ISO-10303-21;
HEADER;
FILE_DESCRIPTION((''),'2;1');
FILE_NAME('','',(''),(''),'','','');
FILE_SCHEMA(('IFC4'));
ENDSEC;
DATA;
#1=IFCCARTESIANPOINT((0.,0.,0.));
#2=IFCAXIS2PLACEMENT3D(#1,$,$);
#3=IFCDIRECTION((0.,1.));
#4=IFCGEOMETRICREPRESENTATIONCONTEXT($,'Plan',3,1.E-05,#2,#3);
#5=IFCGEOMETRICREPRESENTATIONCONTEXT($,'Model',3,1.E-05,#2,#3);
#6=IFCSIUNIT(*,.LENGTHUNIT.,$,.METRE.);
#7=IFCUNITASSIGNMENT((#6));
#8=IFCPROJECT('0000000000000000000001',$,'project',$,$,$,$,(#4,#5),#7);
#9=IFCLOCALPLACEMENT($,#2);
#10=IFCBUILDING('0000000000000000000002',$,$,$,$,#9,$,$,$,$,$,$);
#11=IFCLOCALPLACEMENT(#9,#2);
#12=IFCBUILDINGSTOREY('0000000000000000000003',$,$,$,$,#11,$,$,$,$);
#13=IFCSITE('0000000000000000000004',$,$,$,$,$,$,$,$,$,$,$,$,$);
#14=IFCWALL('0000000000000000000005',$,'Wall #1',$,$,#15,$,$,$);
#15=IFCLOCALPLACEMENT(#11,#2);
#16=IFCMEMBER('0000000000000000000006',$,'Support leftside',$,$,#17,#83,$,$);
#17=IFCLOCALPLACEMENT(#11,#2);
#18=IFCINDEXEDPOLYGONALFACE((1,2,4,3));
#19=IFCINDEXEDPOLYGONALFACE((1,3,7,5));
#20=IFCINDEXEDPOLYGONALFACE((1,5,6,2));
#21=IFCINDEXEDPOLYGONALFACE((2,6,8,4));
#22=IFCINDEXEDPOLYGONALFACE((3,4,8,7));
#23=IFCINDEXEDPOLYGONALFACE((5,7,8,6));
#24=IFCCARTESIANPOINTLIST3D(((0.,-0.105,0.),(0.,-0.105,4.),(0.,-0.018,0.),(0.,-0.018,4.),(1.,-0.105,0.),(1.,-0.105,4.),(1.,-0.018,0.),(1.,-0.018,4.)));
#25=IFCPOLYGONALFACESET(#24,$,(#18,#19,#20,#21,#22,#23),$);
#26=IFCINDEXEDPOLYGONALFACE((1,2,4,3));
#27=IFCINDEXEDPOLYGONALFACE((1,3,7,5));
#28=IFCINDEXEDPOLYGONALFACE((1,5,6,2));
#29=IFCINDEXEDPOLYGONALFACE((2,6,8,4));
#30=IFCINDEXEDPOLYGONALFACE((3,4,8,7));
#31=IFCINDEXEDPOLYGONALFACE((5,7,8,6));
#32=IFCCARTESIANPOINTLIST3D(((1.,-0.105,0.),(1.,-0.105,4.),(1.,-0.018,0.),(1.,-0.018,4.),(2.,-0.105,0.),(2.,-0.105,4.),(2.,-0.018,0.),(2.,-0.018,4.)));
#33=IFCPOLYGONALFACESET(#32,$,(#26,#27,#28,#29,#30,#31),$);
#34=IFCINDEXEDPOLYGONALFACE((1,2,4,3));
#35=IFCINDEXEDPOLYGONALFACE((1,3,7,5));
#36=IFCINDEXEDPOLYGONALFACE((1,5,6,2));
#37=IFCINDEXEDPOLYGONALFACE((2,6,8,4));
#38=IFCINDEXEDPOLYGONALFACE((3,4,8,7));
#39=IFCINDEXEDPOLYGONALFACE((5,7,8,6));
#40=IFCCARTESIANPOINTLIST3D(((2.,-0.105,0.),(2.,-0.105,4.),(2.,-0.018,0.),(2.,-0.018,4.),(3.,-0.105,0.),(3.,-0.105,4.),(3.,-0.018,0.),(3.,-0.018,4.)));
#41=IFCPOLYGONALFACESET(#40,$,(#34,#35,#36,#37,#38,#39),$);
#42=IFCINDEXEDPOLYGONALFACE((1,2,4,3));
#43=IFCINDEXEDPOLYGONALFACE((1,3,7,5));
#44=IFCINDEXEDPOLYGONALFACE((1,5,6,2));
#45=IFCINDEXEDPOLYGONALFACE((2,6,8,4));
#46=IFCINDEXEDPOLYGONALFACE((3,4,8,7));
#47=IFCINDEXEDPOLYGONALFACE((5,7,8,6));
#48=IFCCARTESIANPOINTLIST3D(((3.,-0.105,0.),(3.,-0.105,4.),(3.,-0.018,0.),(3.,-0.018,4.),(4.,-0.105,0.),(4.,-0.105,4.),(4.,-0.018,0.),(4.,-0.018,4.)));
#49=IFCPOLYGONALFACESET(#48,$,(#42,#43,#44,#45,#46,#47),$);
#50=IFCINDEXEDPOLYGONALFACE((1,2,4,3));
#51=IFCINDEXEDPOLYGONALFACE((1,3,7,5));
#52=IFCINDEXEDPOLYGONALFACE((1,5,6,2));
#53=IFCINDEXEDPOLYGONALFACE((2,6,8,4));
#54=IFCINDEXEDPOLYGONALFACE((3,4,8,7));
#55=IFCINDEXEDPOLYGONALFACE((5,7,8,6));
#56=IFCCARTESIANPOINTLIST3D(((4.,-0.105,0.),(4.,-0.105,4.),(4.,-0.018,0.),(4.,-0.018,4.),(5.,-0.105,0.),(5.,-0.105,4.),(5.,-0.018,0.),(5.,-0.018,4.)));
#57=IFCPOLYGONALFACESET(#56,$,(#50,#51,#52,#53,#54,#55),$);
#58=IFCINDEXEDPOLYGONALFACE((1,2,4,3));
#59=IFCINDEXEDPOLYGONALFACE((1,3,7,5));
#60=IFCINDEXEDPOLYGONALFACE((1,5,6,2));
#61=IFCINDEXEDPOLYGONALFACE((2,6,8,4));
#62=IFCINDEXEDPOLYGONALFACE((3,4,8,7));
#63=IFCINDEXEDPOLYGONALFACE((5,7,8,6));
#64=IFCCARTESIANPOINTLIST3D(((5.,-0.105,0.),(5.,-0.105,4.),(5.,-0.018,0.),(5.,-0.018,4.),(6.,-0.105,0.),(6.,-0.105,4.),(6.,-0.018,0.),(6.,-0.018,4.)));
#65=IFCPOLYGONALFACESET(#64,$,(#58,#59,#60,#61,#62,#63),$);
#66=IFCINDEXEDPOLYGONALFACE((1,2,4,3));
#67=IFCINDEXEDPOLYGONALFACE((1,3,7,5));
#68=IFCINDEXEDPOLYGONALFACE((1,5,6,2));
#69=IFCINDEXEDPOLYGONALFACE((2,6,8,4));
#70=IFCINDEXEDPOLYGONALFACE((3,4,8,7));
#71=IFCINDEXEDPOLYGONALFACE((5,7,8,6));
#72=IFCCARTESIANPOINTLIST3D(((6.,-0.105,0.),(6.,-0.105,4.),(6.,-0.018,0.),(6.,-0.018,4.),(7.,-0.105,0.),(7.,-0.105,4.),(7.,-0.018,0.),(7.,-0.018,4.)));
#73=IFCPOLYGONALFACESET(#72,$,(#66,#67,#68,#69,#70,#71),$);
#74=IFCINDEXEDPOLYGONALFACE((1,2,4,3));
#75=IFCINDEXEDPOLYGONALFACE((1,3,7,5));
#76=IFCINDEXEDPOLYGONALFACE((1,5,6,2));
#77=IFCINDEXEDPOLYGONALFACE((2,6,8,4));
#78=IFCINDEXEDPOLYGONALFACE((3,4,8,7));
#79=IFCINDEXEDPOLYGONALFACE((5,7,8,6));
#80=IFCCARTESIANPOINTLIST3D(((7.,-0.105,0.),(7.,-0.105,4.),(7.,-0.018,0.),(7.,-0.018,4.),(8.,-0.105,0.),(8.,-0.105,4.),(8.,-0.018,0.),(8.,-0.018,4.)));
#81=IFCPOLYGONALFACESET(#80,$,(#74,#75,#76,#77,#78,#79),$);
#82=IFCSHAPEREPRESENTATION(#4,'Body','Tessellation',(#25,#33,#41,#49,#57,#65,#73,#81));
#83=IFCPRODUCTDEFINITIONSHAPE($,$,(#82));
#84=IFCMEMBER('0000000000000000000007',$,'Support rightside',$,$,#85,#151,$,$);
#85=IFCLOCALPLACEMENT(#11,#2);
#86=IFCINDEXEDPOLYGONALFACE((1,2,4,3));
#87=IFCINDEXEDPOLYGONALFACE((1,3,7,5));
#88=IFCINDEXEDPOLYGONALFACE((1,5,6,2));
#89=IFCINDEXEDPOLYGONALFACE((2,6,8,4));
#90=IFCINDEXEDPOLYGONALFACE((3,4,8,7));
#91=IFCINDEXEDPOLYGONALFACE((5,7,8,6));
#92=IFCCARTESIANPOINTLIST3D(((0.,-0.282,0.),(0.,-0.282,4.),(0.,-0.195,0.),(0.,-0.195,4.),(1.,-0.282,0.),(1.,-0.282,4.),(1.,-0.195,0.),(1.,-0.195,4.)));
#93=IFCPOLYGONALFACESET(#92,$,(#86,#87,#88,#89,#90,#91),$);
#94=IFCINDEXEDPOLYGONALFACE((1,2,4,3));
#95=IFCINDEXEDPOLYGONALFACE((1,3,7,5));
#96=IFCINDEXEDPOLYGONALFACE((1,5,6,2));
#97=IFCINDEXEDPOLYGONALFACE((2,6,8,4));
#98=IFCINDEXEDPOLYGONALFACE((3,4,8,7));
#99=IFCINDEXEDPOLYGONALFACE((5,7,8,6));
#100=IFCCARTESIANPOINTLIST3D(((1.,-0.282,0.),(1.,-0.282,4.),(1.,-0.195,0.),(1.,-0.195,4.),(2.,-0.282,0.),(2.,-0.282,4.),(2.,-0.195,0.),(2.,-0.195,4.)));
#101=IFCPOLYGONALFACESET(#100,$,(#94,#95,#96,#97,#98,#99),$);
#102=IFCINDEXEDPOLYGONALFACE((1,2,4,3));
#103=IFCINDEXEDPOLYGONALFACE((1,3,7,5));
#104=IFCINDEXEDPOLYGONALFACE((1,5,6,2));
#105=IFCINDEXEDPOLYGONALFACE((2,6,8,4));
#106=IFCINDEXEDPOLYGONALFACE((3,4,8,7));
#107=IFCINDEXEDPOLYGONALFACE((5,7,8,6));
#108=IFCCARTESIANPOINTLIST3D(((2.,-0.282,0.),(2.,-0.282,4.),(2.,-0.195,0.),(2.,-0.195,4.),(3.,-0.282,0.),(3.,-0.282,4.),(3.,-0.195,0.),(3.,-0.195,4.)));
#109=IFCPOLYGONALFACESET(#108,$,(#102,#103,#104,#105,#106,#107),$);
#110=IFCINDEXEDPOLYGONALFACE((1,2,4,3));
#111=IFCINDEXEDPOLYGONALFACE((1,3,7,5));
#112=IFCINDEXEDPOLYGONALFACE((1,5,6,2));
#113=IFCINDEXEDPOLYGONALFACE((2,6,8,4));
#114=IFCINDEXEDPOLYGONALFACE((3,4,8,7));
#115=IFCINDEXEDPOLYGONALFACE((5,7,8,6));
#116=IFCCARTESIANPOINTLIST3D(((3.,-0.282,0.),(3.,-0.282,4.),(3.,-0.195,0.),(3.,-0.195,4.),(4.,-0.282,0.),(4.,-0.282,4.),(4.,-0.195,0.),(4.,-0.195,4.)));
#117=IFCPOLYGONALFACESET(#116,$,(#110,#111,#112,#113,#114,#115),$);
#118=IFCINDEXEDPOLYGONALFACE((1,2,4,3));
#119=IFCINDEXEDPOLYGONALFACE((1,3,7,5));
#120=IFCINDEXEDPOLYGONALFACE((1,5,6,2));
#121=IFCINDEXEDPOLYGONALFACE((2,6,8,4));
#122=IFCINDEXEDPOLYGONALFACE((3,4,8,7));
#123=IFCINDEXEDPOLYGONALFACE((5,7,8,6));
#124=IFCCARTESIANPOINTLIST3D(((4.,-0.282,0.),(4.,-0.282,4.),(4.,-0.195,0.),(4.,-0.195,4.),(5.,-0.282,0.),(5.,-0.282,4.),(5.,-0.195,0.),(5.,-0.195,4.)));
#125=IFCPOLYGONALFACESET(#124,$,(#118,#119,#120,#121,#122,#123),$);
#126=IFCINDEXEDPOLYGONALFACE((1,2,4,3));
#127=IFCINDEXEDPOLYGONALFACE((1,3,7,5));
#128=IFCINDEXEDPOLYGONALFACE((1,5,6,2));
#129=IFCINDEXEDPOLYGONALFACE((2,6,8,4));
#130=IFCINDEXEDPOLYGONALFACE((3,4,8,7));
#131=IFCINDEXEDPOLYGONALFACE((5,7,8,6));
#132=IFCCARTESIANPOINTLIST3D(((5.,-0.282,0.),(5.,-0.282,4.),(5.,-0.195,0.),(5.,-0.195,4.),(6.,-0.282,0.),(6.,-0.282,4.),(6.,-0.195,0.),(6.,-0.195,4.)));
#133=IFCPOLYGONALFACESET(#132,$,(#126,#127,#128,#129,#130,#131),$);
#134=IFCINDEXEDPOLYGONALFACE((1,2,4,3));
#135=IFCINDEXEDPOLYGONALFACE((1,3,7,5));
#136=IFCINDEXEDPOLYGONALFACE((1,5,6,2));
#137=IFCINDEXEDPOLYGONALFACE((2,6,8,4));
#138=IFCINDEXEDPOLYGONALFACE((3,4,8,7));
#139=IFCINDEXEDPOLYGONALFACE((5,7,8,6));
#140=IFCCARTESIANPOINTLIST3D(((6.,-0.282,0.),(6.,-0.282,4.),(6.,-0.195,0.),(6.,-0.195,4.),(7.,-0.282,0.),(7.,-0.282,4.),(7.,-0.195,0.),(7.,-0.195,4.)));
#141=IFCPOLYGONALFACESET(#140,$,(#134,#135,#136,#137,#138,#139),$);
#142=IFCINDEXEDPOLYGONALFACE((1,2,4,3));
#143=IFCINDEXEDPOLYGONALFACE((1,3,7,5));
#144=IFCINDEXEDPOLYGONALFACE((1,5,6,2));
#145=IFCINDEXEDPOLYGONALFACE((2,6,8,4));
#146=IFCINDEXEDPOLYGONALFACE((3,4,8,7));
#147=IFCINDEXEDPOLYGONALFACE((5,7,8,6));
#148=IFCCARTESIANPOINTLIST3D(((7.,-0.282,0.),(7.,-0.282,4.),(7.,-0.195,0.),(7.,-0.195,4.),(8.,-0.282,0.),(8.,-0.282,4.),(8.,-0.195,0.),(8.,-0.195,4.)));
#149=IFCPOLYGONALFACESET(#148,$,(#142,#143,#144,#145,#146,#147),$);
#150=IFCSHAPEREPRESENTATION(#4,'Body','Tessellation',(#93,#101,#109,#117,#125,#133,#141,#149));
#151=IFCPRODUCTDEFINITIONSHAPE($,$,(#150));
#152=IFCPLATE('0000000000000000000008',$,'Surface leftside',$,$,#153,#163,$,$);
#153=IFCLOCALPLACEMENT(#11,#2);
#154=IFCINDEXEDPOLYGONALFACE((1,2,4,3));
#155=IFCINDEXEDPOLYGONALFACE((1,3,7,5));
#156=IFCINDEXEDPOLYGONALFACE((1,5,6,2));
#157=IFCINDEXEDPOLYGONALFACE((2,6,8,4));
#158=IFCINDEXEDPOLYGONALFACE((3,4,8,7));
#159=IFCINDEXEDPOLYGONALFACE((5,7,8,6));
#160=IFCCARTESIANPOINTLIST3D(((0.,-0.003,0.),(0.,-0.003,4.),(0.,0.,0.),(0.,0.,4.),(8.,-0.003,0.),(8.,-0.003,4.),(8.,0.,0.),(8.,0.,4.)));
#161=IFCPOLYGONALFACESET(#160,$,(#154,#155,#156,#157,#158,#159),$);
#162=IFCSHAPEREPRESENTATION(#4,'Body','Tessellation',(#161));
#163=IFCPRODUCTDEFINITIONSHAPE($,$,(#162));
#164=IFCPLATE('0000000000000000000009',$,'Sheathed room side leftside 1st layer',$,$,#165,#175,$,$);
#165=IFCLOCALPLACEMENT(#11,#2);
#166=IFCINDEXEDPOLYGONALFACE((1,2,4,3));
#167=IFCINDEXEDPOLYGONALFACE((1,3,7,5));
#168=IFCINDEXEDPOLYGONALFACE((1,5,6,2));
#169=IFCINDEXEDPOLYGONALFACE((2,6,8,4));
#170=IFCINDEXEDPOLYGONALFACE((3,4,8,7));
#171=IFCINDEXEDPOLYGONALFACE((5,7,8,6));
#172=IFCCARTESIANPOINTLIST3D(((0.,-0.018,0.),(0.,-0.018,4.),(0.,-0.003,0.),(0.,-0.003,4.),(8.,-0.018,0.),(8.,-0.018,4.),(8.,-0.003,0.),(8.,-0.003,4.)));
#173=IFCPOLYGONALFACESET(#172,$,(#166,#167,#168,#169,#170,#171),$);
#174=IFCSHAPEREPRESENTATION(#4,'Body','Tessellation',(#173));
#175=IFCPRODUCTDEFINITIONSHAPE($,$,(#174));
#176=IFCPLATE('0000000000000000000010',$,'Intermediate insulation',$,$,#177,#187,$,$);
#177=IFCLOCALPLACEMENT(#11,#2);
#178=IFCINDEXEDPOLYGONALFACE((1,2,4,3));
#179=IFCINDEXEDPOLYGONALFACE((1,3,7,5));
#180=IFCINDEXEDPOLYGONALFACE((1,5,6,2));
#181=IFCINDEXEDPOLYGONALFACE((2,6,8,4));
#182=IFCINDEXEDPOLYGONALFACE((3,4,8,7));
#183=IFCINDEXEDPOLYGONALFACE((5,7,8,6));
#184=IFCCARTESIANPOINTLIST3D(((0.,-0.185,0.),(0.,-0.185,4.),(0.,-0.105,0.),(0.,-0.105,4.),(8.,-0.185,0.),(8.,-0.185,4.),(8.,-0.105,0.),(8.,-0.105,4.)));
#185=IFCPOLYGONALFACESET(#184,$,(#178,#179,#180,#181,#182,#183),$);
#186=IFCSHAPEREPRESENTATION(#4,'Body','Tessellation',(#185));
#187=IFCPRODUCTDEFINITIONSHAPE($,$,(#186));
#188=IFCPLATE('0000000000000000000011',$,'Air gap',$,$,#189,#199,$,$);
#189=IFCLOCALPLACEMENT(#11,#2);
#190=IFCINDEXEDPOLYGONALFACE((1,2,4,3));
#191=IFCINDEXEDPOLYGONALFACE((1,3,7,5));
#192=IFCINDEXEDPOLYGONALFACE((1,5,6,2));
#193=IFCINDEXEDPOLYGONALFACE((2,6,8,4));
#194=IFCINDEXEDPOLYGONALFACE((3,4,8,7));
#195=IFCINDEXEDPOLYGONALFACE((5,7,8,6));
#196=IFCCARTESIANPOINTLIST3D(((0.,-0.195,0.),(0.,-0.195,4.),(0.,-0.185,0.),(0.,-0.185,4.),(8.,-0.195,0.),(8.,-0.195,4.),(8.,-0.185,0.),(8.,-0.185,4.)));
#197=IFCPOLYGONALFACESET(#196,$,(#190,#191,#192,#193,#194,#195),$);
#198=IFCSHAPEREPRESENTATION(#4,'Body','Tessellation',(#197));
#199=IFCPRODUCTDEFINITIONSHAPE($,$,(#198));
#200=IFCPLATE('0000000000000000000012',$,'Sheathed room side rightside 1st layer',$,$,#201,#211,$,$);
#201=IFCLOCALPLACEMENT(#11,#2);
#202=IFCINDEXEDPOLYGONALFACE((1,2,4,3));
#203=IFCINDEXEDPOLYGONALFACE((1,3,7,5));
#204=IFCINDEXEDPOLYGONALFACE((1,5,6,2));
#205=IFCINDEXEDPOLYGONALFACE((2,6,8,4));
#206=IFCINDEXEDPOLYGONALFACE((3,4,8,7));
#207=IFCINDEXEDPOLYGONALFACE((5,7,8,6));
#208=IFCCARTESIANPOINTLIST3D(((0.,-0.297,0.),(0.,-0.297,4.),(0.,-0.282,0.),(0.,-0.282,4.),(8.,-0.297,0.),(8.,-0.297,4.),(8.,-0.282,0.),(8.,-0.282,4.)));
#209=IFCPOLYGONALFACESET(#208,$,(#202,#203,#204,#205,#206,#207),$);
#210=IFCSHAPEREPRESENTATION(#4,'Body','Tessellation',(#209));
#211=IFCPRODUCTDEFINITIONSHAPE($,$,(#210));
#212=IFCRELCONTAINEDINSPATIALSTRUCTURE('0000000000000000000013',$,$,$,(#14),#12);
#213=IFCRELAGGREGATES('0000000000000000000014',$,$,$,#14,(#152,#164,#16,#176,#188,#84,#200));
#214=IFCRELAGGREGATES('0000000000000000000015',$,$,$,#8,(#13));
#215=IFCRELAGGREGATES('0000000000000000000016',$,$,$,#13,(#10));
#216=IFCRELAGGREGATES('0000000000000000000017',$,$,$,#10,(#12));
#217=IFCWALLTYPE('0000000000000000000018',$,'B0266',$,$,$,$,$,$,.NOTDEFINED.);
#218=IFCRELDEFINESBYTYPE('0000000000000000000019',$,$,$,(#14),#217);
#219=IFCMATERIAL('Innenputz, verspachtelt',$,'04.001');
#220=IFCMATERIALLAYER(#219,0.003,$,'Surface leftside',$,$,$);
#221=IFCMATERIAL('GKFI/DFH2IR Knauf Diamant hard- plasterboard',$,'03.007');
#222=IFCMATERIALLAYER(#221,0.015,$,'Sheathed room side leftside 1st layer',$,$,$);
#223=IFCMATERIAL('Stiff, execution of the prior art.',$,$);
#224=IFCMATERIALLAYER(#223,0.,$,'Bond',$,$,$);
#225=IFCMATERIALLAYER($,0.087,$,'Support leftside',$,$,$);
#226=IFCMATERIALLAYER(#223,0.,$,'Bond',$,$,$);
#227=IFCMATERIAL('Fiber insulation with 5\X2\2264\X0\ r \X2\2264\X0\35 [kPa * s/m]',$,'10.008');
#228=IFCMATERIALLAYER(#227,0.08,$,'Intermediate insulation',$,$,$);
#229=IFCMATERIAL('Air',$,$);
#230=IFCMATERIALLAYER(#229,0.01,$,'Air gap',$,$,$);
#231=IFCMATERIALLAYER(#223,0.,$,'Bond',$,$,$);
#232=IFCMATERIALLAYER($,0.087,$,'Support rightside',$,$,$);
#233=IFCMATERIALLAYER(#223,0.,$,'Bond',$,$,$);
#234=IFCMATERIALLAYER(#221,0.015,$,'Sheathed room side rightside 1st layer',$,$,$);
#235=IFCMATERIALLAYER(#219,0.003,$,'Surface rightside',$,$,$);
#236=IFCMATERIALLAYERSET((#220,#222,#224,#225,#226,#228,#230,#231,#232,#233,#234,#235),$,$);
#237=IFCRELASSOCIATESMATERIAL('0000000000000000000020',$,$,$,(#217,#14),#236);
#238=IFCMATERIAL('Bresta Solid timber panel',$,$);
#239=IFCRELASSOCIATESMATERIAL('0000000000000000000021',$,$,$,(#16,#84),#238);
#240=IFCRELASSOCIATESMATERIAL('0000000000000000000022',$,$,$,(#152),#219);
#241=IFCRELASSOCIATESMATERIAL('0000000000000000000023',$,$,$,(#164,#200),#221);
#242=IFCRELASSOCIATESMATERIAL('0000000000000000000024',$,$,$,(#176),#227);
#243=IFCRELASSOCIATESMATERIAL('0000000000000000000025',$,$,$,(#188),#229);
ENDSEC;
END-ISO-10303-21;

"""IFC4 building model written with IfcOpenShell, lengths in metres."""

from ifc_helpers import new_model, si_unit, direction, frame, frame_2d, origin, origin_with_axes, place, context, project, spatial, rectangle, extrude, material, layer, layer_set, type_object, element, aggregate, save


model = new_model("IFC4")

# Units and contexts
plan_context = context("Plan", 3, precision=1e-05, world=origin(), true_north=direction((0.0, 1.0)))
model_context = context("Model", 3, precision=1e-05, world=origin(), true_north=direction((0.0, 1.0)))
ifc_project = project(units=[si_unit("LENGTHUNIT", "METRE")], contexts=[plan_context, model_context])

# Site, building, storey
site = spatial("IfcSite", under=ifc_project)
building_placement = place(None, origin())
building = spatial("IfcBuilding", under=site, at=building_placement)
storey_placement = place(building_placement, origin())
storey = spatial("IfcBuildingStorey", under=building, at=storey_placement)

# Wall, members, plates
ifc_material_1 = material(Name="Innenputz, verspachtelt", Category="04.001")
ifc_layer_1 = layer(ifc_material_1, 0.003, Name="Surface leftside")
ifc_material_2 = material(Name="GKFI/DFH2IR Knauf Diamant hard- plasterboard", Category="03.007")
ifc_layer_2 = layer(ifc_material_2, 0.015, Name="Sheathed room side leftside 1st layer")
ifc_material_3 = material(Name="Stiff, execution of the prior art.")
ifc_layer_3 = layer(ifc_material_3, 0.0, Name="Bond")
ifc_layer_4 = layer(None, 0.087, Name="Support leftside")
ifc_layer_5 = layer(ifc_material_3, 0.0, Name="Bond")
ifc_material_4 = material(Name="Fiber insulation with 5≤ r ≤35 [kPa * s/m]", Category="10.008")
ifc_layer_6 = layer(ifc_material_4, 0.08, Name="Intermediate insulation")
ifc_material_5 = material(Name="Air")
ifc_layer_7 = layer(ifc_material_5, 0.01, Name="Air gap")
ifc_layer_8 = layer(ifc_material_3, 0.0, Name="Bond")
ifc_layer_9 = layer(None, 0.087, Name="Support rightside")
ifc_layer_10 = layer(ifc_material_3, 0.0, Name="Bond")
ifc_layer_11 = layer(ifc_material_2, 0.015, Name="Sheathed room side rightside 1st layer")
ifc_layer_12 = layer(ifc_material_1, 0.003, Name="Surface rightside")
ifc_layer_set = layer_set([ifc_layer_1, ifc_layer_2, ifc_layer_3, ifc_layer_4, ifc_layer_5, ifc_layer_6, ifc_layer_7, ifc_layer_8, ifc_layer_9, ifc_layer_10, ifc_layer_11, ifc_layer_12])
wall_type = type_object("IfcWallType", Name="B0266", PredefinedType="NOTDEFINED", material=ifc_layer_set)
wall_placement = place(None, frame((0.0, 0.0, 0.0), z_axis=(0.0, -1.0, 0.0), x_axis=(1.0, 0.0, 0.0)))
wall = element("IfcWall", 1, at=wall_placement, inside=storey, type_object=wall_type, material=ifc_layer_set, Name="Wall #1")
ifc_material_6 = material(Name="Bresta Solid timber panel")
member_1_placement = place(wall_placement, origin())
member_1 = element("IfcMember", 2, at=member_1_placement, material=ifc_material_6, Name="Support leftside", context=plan_context, shape_type="SweptSolid", body=[
    extrude(rectangle(XDim=1.0, YDim=0.087, at=frame_2d((0.5, 0.0435), x_axis=(1.0, 0.0))), frame((0.0, 4.0, 0.018), z_axis=(0.0, -1.0, 0.0), x_axis=(1.0, 0.0, 0.0)), (0.0, 0.0, 1.0), 4.0),
    extrude(rectangle(XDim=1.0, YDim=0.087, at=frame_2d((0.5, 0.0435), x_axis=(1.0, 0.0))), frame((1.0, 4.0, 0.018), z_axis=(0.0, -1.0, 0.0), x_axis=(1.0, 0.0, 0.0)), (0.0, 0.0, 1.0), 4.0),
    extrude(rectangle(XDim=1.0, YDim=0.087, at=frame_2d((0.5, 0.0435), x_axis=(1.0, 0.0))), frame((2.0, 4.0, 0.018), z_axis=(0.0, -1.0, 0.0), x_axis=(1.0, 0.0, 0.0)), (0.0, 0.0, 1.0), 4.0),
    extrude(rectangle(XDim=1.0, YDim=0.087, at=frame_2d((0.5, 0.0435), x_axis=(1.0, 0.0))), frame((3.0, 4.0, 0.018), z_axis=(0.0, -1.0, 0.0), x_axis=(1.0, 0.0, 0.0)), (0.0, 0.0, 1.0), 4.0),
    extrude(rectangle(XDim=1.0, YDim=0.087, at=frame_2d((0.5, 0.0435), x_axis=(1.0, 0.0))), frame((4.0, 4.0, 0.018), z_axis=(0.0, -1.0, 0.0), x_axis=(1.0, 0.0, 0.0)), (0.0, 0.0, 1.0), 4.0),
    extrude(rectangle(XDim=1.0, YDim=0.087, at=frame_2d((0.5, 0.0435), x_axis=(1.0, 0.0))), frame((5.0, 4.0, 0.018), z_axis=(0.0, -1.0, 0.0), x_axis=(1.0, 0.0, 0.0)), (0.0, 0.0, 1.0), 4.0),
    extrude(rectangle(XDim=1.0, YDim=0.087, at=frame_2d((0.5, 0.0435), x_axis=(1.0, 0.0))), frame((6.0, 4.0, 0.018), z_axis=(0.0, -1.0, 0.0), x_axis=(1.0, 0.0, 0.0)), (0.0, 0.0, 1.0), 4.0),
    extrude(rectangle(XDim=1.0, YDim=0.087, at=frame_2d((0.5, 0.0435), x_axis=(1.0, 0.0))), frame((7.0, 4.0, 0.018), z_axis=(0.0, -1.0, 0.0), x_axis=(1.0, 0.0, 0.0)), (0.0, 0.0, 1.0), 4.0),
])
member_2_placement = place(wall_placement, origin())
member_2 = element("IfcMember", 3, at=member_2_placement, material=ifc_material_6, Name="Support rightside", context=plan_context, shape_type="SweptSolid", body=[
    extrude(rectangle(XDim=1.0, YDim=0.087, at=frame_2d((0.5, 0.0435), x_axis=(1.0, 0.0))), frame((0.0, 4.0, 0.195), z_axis=(0.0, -1.0, 0.0), x_axis=(1.0, 0.0, 0.0)), (0.0, 0.0, 1.0), 4.0),
    extrude(rectangle(XDim=1.0, YDim=0.087, at=frame_2d((0.5, 0.0435), x_axis=(1.0, 0.0))), frame((1.0, 4.0, 0.195), z_axis=(0.0, -1.0, 0.0), x_axis=(1.0, 0.0, 0.0)), (0.0, 0.0, 1.0), 4.0),
    extrude(rectangle(XDim=1.0, YDim=0.087, at=frame_2d((0.5, 0.0435), x_axis=(1.0, 0.0))), frame((2.0, 4.0, 0.195), z_axis=(0.0, -1.0, 0.0), x_axis=(1.0, 0.0, 0.0)), (0.0, 0.0, 1.0), 4.0),
    extrude(rectangle(XDim=1.0, YDim=0.087, at=frame_2d((0.5, 0.0435), x_axis=(1.0, 0.0))), frame((3.0, 4.0, 0.195), z_axis=(0.0, -1.0, 0.0), x_axis=(1.0, 0.0, 0.0)), (0.0, 0.0, 1.0), 4.0),
    extrude(rectangle(XDim=1.0, YDim=0.087, at=frame_2d((0.5, 0.0435), x_axis=(1.0, 0.0))), frame((4.0, 4.0, 0.195), z_axis=(0.0, -1.0, 0.0), x_axis=(1.0, 0.0, 0.0)), (0.0, 0.0, 1.0), 4.0),
    extrude(rectangle(XDim=1.0, YDim=0.087, at=frame_2d((0.5, 0.0435), x_axis=(1.0, 0.0))), frame((5.0, 4.0, 0.195), z_axis=(0.0, -1.0, 0.0), x_axis=(1.0, 0.0, 0.0)), (0.0, 0.0, 1.0), 4.0),
    extrude(rectangle(XDim=1.0, YDim=0.087, at=frame_2d((0.5, 0.0435), x_axis=(1.0, 0.0))), frame((6.0, 4.0, 0.195), z_axis=(0.0, -1.0, 0.0), x_axis=(1.0, 0.0, 0.0)), (0.0, 0.0, 1.0), 4.0),
    extrude(rectangle(XDim=1.0, YDim=0.087, at=frame_2d((0.5, 0.0435), x_axis=(1.0, 0.0))), frame((7.0, 4.0, 0.195), z_axis=(0.0, -1.0, 0.0), x_axis=(1.0, 0.0, 0.0)), (0.0, 0.0, 1.0), 4.0),
])
plate_1_placement = place(wall_placement, origin())
plate_1 = element("IfcPlate", 4, at=plate_1_placement, material=ifc_material_1, Name="Surface leftside", context=plan_context, shape_type="SweptSolid", body=[
    extrude(rectangle(XDim=8.0, YDim=4.0, at=frame_2d((4.0, 2.0), x_axis=(1.0, 0.0))), origin_with_axes(), (0.0, 0.0, 1.0), 0.003),
])
plate_2_placement = place(wall_placement, origin())
plate_2 = element("IfcPlate", 5, at=plate_2_placement, material=ifc_material_2, Name="Sheathed room side leftside 1st layer", context=plan_context, shape_type="SweptSolid", body=[
    extrude(rectangle(XDim=8.0, YDim=4.0, at=frame_2d((4.0, 2.0), x_axis=(1.0, 0.0))), frame((0.0, 0.0, 0.003), z_axis=(0.0, 0.0, 1.0), x_axis=(1.0, 0.0, 0.0)), (0.0, 0.0, 1.0), 0.015),
])
plate_3_placement = place(wall_placement, origin())
plate_3 = element("IfcPlate", 6, at=plate_3_placement, material=ifc_material_4, Name="Intermediate insulation", context=plan_context, shape_type="SweptSolid", body=[
    extrude(rectangle(XDim=8.0, YDim=4.0, at=frame_2d((4.0, 2.0), x_axis=(1.0, 0.0))), frame((0.0, 0.0, 0.105), z_axis=(0.0, 0.0, 1.0), x_axis=(1.0, 0.0, 0.0)), (0.0, 0.0, 1.0), 0.08),
])
plate_4_placement = place(wall_placement, origin())
plate_4 = element("IfcPlate", 7, at=plate_4_placement, material=ifc_material_5, Name="Air gap", context=plan_context, shape_type="SweptSolid", body=[
    extrude(rectangle(XDim=8.0, YDim=4.0, at=frame_2d((4.0, 2.0), x_axis=(1.0, 0.0))), frame((0.0, 0.0, 0.185), z_axis=(0.0, 0.0, 1.0), x_axis=(1.0, 0.0, 0.0)), (0.0, 0.0, 1.0), 0.01),
])
plate_5_placement = place(wall_placement, origin())
plate_5 = element("IfcPlate", 8, at=plate_5_placement, material=ifc_material_2, Name="Sheathed room side rightside 1st layer", context=plan_context, shape_type="SweptSolid", body=[
    extrude(rectangle(XDim=8.0, YDim=4.0, at=frame_2d((4.0, 2.0), x_axis=(1.0, 0.0))), frame((0.0, 0.0, 0.282), z_axis=(0.0, 0.0, 1.0), x_axis=(1.0, 0.0, 0.0)), (0.0, 0.0, 1.0), 0.015),
])
aggregate(wall, [plate_1, plate_2, member_1, plate_3, plate_4, member_2, plate_5])

save(model, "model.ifc")
